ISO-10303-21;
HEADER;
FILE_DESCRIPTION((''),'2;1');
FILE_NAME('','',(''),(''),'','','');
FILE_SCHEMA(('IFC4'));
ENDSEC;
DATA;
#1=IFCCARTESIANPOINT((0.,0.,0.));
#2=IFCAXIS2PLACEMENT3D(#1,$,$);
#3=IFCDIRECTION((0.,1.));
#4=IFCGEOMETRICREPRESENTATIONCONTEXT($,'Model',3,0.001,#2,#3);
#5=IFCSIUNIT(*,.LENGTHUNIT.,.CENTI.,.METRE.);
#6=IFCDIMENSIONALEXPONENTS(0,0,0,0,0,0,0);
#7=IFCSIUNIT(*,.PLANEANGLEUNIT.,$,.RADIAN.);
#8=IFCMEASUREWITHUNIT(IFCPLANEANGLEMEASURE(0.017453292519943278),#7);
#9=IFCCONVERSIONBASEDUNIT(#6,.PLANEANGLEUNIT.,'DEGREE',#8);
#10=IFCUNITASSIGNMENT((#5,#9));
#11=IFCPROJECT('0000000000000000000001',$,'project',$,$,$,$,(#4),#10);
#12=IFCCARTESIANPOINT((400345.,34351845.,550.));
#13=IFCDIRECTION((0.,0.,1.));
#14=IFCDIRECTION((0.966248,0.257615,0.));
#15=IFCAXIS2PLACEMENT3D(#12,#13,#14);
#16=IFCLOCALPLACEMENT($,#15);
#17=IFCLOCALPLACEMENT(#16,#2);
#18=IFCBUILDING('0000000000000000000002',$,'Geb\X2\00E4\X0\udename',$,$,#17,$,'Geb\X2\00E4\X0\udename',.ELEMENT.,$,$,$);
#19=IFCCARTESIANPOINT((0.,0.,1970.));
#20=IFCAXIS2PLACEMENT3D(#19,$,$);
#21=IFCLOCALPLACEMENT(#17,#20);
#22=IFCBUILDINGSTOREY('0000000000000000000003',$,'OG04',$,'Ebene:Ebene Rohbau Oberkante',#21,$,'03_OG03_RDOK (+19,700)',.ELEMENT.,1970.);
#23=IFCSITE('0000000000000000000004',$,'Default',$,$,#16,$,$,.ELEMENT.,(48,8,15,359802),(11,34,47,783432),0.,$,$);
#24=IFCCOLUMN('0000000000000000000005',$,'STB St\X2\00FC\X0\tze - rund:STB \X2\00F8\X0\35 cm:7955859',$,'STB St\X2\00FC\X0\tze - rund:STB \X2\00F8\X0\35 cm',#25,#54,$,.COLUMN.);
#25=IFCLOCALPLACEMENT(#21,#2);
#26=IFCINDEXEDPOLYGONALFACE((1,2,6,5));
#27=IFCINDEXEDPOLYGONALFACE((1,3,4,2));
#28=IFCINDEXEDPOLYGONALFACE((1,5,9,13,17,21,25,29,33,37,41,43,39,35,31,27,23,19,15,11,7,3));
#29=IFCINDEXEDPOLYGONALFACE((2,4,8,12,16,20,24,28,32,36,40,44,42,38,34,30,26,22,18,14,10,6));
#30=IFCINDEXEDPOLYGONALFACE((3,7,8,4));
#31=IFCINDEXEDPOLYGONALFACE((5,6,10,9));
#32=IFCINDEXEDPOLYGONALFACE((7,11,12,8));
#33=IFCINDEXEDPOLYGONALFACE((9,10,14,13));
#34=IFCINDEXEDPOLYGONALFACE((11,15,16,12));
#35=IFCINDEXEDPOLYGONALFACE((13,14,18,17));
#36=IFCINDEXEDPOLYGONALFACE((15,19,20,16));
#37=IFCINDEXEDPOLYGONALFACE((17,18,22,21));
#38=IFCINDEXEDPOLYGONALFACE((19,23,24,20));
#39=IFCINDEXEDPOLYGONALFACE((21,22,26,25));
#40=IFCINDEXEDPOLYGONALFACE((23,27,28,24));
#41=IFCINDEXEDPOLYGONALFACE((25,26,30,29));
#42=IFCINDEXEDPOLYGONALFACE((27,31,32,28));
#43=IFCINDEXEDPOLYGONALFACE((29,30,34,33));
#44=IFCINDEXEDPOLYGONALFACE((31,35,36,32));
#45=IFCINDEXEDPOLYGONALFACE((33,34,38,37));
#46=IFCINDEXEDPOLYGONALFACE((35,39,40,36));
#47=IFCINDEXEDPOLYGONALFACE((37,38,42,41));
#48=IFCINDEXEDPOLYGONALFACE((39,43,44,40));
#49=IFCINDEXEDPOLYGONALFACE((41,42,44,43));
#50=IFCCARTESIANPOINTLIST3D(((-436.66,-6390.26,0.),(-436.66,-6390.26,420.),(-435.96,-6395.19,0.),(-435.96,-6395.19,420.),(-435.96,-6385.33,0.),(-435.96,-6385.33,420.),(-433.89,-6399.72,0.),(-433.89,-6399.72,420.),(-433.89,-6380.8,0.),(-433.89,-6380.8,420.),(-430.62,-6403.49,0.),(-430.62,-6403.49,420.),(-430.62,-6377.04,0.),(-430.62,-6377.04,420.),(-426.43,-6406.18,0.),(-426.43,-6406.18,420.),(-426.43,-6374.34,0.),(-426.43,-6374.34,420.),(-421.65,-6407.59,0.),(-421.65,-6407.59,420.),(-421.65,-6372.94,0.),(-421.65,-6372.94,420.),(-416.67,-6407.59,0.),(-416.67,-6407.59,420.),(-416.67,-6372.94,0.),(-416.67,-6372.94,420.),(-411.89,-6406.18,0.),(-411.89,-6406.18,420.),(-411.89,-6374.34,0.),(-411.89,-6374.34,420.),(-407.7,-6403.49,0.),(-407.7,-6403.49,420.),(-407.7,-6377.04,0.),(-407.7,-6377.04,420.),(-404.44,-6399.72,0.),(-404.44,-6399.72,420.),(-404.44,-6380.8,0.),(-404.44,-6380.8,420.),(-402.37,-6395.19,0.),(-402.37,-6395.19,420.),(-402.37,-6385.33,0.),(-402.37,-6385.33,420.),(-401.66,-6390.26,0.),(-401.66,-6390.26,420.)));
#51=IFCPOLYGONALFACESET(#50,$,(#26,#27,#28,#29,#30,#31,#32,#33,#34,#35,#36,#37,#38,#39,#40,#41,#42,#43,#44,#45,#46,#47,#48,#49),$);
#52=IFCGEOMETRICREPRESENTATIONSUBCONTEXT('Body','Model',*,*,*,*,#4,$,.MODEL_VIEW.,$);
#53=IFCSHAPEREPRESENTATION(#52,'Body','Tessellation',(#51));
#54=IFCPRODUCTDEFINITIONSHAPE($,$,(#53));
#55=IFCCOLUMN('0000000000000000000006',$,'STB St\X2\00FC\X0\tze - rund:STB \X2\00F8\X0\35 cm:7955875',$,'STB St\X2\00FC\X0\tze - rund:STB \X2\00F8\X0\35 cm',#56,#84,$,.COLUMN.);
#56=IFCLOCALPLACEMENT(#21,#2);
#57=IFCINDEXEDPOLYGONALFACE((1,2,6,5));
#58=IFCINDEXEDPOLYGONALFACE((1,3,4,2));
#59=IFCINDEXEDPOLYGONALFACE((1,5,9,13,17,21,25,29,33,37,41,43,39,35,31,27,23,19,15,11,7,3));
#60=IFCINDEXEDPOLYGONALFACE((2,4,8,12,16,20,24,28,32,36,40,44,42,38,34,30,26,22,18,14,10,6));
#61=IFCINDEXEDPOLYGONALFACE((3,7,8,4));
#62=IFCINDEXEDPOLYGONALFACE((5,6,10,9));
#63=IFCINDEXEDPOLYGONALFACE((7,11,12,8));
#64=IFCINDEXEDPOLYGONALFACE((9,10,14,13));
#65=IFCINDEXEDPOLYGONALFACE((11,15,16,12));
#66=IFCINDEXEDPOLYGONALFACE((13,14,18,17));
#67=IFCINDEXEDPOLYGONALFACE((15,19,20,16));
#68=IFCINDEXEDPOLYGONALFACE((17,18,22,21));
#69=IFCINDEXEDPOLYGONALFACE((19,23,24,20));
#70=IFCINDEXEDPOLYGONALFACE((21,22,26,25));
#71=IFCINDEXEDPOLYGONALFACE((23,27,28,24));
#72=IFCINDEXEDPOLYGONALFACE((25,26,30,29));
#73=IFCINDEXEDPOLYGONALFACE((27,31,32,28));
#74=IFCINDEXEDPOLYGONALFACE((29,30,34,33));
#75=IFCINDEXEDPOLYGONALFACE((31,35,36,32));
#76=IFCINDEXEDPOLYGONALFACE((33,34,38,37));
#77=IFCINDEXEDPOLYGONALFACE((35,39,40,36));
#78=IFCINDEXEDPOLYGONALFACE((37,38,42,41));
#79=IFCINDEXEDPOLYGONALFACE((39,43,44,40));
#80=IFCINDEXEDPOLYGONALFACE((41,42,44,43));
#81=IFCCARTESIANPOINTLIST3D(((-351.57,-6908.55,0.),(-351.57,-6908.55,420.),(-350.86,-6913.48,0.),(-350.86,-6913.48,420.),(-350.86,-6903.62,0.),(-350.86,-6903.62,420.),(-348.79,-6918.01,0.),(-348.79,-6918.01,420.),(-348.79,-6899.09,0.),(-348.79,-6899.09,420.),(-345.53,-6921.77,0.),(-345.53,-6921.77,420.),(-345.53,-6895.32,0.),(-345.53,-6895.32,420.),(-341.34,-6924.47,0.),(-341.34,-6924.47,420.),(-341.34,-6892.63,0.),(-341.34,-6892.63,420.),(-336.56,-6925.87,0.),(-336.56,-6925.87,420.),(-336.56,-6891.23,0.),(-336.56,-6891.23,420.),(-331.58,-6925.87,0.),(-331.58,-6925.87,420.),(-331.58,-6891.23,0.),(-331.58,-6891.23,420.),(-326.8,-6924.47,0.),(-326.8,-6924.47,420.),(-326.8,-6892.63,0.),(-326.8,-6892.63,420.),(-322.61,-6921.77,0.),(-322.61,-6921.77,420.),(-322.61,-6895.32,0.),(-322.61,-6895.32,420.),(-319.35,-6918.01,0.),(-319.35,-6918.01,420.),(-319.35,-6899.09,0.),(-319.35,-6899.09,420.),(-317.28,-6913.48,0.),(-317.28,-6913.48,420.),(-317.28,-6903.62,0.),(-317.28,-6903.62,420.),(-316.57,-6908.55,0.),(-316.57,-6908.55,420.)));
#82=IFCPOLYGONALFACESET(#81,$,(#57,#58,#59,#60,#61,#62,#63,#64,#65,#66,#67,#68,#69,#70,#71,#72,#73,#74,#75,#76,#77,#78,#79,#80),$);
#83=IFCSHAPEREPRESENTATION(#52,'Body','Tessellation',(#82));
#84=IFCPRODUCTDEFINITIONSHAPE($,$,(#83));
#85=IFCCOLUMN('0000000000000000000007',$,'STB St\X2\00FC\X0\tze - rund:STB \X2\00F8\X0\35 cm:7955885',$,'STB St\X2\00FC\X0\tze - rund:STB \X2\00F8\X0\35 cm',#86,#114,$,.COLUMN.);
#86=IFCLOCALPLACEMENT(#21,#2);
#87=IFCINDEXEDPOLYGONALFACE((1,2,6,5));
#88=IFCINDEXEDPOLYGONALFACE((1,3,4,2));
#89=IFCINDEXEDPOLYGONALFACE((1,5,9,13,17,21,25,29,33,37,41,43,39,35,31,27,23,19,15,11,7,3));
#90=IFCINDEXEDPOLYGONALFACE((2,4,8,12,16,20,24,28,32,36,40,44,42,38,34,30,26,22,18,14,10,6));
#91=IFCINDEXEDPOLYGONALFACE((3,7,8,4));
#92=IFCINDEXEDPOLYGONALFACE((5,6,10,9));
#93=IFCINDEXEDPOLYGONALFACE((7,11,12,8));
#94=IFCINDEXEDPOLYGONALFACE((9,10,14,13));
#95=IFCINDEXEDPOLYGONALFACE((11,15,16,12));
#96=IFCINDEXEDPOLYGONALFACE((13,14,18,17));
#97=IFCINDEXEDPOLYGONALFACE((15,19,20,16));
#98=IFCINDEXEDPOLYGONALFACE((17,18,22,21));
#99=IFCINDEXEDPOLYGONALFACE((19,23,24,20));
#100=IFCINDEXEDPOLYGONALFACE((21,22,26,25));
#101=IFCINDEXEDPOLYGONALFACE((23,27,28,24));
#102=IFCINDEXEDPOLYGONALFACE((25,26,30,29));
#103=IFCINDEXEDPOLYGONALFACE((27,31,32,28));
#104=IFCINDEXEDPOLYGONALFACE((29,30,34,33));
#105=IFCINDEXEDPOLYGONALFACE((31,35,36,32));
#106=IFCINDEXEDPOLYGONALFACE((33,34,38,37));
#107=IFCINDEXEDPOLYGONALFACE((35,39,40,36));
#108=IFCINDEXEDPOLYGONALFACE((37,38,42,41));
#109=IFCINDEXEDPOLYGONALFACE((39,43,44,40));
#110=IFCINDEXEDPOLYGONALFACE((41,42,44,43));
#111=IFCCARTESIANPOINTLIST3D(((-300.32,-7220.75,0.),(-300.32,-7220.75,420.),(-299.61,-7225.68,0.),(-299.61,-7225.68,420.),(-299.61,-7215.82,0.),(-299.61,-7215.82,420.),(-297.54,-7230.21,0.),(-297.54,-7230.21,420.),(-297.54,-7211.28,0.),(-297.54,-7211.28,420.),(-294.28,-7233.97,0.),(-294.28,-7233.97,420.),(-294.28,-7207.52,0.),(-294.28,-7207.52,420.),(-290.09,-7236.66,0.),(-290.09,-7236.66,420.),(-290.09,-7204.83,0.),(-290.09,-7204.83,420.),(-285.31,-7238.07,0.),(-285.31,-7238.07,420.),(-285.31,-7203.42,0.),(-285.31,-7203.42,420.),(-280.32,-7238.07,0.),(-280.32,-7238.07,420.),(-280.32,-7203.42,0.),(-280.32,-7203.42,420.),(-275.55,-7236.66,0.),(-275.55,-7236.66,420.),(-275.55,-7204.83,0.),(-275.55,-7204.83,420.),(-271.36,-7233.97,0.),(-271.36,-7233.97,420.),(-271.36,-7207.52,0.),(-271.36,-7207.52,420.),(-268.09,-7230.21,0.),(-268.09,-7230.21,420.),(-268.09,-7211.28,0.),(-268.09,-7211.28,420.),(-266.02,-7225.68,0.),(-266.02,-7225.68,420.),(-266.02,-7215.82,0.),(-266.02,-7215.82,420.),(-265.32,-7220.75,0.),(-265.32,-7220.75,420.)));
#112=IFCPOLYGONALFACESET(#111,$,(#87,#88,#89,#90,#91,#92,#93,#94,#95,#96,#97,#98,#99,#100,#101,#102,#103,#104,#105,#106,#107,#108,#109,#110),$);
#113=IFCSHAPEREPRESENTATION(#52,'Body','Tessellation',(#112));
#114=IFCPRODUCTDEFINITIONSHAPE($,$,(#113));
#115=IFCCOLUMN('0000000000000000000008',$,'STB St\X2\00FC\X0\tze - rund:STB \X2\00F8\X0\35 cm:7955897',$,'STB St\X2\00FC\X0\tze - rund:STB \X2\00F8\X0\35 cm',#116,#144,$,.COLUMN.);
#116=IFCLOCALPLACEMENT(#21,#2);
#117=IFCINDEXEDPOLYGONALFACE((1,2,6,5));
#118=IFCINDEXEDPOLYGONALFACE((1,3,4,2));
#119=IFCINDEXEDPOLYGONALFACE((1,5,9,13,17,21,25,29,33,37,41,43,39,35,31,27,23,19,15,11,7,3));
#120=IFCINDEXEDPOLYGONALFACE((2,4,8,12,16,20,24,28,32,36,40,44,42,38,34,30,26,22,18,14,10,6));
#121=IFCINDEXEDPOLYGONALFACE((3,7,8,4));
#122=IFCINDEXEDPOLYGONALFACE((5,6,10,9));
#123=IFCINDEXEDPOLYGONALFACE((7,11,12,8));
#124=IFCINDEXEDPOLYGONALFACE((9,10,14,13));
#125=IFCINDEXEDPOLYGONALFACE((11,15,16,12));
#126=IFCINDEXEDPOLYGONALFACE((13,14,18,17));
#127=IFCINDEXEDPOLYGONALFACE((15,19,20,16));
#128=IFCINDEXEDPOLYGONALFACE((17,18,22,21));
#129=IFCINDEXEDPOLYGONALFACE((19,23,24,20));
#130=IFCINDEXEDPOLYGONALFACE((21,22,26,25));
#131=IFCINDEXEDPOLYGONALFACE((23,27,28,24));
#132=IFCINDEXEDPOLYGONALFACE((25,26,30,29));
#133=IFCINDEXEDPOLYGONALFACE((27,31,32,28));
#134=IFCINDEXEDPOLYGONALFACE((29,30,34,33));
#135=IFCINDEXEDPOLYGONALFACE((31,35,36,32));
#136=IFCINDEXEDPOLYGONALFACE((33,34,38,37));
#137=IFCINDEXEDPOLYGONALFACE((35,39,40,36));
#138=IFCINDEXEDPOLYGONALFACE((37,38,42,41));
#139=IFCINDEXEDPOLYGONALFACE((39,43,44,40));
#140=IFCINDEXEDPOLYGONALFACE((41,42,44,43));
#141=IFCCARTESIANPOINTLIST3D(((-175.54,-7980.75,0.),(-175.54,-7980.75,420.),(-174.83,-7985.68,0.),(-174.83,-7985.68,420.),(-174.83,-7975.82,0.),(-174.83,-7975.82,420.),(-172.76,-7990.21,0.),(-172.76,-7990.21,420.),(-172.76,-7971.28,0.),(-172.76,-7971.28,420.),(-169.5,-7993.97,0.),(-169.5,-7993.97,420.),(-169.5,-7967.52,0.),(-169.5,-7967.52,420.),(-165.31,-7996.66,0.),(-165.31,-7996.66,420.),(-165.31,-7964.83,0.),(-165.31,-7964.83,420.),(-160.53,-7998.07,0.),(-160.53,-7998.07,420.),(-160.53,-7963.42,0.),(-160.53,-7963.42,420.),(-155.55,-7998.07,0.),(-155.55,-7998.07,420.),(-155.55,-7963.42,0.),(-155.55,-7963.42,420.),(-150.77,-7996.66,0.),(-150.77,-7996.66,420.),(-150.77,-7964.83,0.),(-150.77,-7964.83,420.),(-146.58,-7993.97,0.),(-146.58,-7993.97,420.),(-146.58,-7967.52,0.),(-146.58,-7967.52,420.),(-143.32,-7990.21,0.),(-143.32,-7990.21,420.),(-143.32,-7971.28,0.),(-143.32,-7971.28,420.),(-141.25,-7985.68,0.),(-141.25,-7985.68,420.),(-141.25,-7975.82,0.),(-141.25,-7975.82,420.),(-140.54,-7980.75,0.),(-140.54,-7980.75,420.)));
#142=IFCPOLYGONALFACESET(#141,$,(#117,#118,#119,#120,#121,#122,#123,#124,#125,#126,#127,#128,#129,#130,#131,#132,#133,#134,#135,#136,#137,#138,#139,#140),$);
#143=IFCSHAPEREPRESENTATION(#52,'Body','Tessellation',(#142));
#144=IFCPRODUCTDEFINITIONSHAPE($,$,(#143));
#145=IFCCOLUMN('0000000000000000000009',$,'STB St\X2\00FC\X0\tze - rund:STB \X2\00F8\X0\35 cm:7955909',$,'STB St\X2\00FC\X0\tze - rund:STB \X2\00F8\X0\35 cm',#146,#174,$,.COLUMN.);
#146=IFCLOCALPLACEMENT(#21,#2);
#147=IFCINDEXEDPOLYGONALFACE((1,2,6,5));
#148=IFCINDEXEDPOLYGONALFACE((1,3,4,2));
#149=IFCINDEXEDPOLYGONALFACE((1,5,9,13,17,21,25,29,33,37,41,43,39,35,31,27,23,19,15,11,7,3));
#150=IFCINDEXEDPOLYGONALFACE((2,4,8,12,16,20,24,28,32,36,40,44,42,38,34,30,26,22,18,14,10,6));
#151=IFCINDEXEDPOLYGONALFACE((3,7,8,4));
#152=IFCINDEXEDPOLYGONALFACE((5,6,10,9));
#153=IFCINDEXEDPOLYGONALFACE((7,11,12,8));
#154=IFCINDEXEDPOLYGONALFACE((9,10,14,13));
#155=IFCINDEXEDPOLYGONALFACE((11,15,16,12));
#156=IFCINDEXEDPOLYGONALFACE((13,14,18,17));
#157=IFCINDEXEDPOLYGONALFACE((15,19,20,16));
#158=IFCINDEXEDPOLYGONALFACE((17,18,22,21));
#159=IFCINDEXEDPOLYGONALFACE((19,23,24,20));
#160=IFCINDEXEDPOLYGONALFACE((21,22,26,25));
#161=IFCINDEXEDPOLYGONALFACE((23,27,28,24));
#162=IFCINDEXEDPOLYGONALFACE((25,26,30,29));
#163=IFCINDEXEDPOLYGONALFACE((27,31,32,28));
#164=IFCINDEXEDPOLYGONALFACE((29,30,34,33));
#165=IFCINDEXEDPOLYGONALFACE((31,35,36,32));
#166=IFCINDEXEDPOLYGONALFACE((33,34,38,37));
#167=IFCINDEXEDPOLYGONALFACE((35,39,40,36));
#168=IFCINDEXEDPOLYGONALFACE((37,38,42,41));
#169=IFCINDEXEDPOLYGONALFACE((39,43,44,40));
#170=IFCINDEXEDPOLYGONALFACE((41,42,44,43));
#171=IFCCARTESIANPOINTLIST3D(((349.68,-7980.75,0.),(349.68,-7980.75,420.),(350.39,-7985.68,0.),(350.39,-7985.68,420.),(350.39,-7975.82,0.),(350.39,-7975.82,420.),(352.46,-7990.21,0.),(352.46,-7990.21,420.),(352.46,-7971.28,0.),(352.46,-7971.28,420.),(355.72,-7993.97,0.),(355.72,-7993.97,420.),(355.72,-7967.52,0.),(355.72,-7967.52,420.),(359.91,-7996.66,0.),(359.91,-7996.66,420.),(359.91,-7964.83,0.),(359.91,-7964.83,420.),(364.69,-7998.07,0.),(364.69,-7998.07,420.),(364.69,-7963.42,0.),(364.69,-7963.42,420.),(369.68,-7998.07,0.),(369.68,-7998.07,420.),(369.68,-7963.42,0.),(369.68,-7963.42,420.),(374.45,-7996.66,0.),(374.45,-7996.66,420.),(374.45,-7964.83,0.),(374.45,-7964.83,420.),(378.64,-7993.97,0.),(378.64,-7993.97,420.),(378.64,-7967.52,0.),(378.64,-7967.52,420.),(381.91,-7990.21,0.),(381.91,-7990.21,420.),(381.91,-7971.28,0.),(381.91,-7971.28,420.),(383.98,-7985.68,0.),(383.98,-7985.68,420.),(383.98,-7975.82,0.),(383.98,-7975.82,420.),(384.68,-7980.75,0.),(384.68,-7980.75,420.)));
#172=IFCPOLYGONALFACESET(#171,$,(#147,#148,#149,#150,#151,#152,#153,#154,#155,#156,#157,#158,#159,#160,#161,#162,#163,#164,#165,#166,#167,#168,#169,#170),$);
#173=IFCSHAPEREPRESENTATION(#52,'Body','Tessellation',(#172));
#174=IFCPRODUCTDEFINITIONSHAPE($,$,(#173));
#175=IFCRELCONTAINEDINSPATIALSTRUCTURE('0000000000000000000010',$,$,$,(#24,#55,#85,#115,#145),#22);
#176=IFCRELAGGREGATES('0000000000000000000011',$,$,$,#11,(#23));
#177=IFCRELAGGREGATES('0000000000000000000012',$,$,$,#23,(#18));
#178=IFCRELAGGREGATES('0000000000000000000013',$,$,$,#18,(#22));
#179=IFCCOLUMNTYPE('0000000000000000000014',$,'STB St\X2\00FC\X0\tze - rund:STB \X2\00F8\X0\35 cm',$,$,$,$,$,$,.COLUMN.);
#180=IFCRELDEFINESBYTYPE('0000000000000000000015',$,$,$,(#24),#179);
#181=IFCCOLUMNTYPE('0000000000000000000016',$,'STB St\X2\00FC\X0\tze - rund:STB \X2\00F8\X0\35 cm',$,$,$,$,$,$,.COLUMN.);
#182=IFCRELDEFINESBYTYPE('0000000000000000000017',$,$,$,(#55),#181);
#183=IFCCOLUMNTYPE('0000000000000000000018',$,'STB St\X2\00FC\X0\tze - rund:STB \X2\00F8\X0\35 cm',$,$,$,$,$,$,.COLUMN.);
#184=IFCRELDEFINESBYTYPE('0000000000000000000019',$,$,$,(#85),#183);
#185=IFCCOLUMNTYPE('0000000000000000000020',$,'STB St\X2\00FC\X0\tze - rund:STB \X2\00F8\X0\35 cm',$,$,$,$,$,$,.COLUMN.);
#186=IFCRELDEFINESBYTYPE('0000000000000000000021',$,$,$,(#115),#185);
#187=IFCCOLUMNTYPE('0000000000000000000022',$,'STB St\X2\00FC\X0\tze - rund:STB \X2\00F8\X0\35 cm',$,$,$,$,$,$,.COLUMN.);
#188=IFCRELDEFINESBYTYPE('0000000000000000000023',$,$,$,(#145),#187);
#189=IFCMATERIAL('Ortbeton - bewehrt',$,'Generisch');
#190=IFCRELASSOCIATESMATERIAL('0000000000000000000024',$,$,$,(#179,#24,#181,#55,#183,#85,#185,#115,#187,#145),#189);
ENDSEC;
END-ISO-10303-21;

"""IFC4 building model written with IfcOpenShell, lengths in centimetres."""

from ifc_helpers import new_model, entity, si_unit, converted_unit, direction, frame, origin, place, context, subcontext, project, spatial, arc, indexed_curve, outline, extrude, source, transform, mapped, material, type_object, type_shapes, element, save


model = new_model("IFC4")

# Units and contexts
model_context = context("Model", 3, precision=0.001, world=origin(), true_north=direction((0.0, 1.0)))
body_context = subcontext(model_context, "Body", "Model", "MODEL_VIEW")
ifc_project = project(units=[si_unit("LENGTHUNIT", "METRE", prefix="CENTI"), converted_unit("PLANEANGLEUNIT", "DEGREE", entity("IfcPlaneAngleMeasure", 0.017453292519943278), si_unit("PLANEANGLEUNIT", "RADIAN"), dimensions=[0, 0, 0, 0, 0, 0, 0])], contexts=[model_context])

# Site, building, storey
site_placement = place(None, frame((400345.0, 34351845.0, 550.0), z_axis=(0.0, 0.0, 1.0), x_axis=(0.966248, 0.257615, 0.0)))
site = spatial("IfcSite", under=ifc_project, at=site_placement, Name="Default", CompositionType="ELEMENT", RefLatitude=(48, 8, 15, 359802), RefLongitude=(11, 34, 47, 783432), RefElevation=0.0)
building_placement = place(site_placement, origin())
building = spatial("IfcBuilding", under=site, at=building_placement, Name="Gebäudename", LongName="Gebäudename", CompositionType="ELEMENT")
storey_placement = place(building_placement, frame((0.0, 0.0, 1970.0)))
storey = spatial("IfcBuildingStorey", under=building, at=storey_placement, Name="OG04", ObjectType="Ebene:Ebene Rohbau Oberkante", LongName="03_OG03_RDOK (+19,700)", CompositionType="ELEMENT", Elevation=1970.0)

# Columns
ifc_material = material(Name="Ortbeton - bewehrt", Category="Generisch")
column_type_1 = type_object("IfcColumnType", Name="STB Stütze - rund:STB ø35 cm", PredefinedType="COLUMN", material=ifc_material)
shared_shape_1 = source(origin(), body_context, "Body", "SweptSolid", [
    extrude(outline(indexed_curve([(-17.5, 0.0), (0.0, -17.5), (17.5, 0.0), (0.0, 17.5)], segments=[arc(1, 2, 3), arc(3, 4, 1)], self_intersect=False)), frame((-419.16, -6390.26, 1970.0)), (0.0, 0.0, 1.0), 420.0),
])
type_shapes(column_type_1, [shared_shape_1])
column_1_placement = place(storey_placement, frame((0.0, 0.0, -1970.0)))
element("IfcColumn", 1, at=column_1_placement, inside=storey, type_object=column_type_1, material=ifc_material, Name="STB Stütze - rund:STB ø35 cm:7955859", ObjectType="STB Stütze - rund:STB ø35 cm", PredefinedType="COLUMN", context=body_context, shape_type="MappedRepresentation", body=[
    mapped(shared_shape_1, transform((0.0, 0.0, 0.0), scale=1.0)),
])
column_type_2 = type_object("IfcColumnType", Name="STB Stütze - rund:STB ø35 cm", PredefinedType="COLUMN", material=ifc_material)
shared_shape_2 = source(origin(), body_context, "Body", "SweptSolid", [
    extrude(outline(indexed_curve([(-17.5, 0.0), (0.0, -17.5), (17.5, 0.0), (0.0, 17.5)], segments=[arc(1, 2, 3), arc(3, 4, 1)], self_intersect=False)), frame((-334.07, -6908.55, 1970.0)), (0.0, 0.0, 1.0), 420.0),
])
type_shapes(column_type_2, [shared_shape_2])
column_2_placement = place(storey_placement, frame((0.0, 0.0, -1970.0)))
element("IfcColumn", 2, at=column_2_placement, inside=storey, type_object=column_type_2, material=ifc_material, Name="STB Stütze - rund:STB ø35 cm:7955875", ObjectType="STB Stütze - rund:STB ø35 cm", PredefinedType="COLUMN", context=body_context, shape_type="MappedRepresentation", body=[
    mapped(shared_shape_2, transform((0.0, 0.0, 0.0), scale=1.0)),
])
column_type_3 = type_object("IfcColumnType", Name="STB Stütze - rund:STB ø35 cm", PredefinedType="COLUMN", material=ifc_material)
shared_shape_3 = source(origin(), body_context, "Body", "SweptSolid", [
    extrude(outline(indexed_curve([(-17.5, 0.0), (0.0, -17.5), (17.5, 0.0), (0.0, 17.5)], segments=[arc(1, 2, 3), arc(3, 4, 1)], self_intersect=False)), frame((-282.82, -7220.75, 1970.0)), (0.0, 0.0, 1.0), 420.0),
])
type_shapes(column_type_3, [shared_shape_3])
column_3_placement = place(storey_placement, frame((0.0, 0.0, -1970.0)))
element("IfcColumn", 3, at=column_3_placement, inside=storey, type_object=column_type_3, material=ifc_material, Name="STB Stütze - rund:STB ø35 cm:7955885", ObjectType="STB Stütze - rund:STB ø35 cm", PredefinedType="COLUMN", context=body_context, shape_type="MappedRepresentation", body=[
    mapped(shared_shape_3, transform((0.0, 0.0, 0.0), scale=1.0)),
])
column_type_4 = type_object("IfcColumnType", Name="STB Stütze - rund:STB ø35 cm", PredefinedType="COLUMN", material=ifc_material)
shared_shape_4 = source(origin(), body_context, "Body", "SweptSolid", [
    extrude(outline(indexed_curve([(-17.5, 0.0), (0.0, -17.5), (17.5, 0.0), (0.0, 17.5)], segments=[arc(1, 2, 3), arc(3, 4, 1)], self_intersect=False)), frame((-158.04, -7980.75, 1970.0)), (0.0, 0.0, 1.0), 420.0),
])
type_shapes(column_type_4, [shared_shape_4])
column_4_placement = place(storey_placement, frame((0.0, 0.0, -1970.0)))
element("IfcColumn", 4, at=column_4_placement, inside=storey, type_object=column_type_4, material=ifc_material, Name="STB Stütze - rund:STB ø35 cm:7955897", ObjectType="STB Stütze - rund:STB ø35 cm", PredefinedType="COLUMN", context=body_context, shape_type="MappedRepresentation", body=[
    mapped(shared_shape_4, transform((0.0, 0.0, 0.0), scale=1.0)),
])
column_type_5 = type_object("IfcColumnType", Name="STB Stütze - rund:STB ø35 cm", PredefinedType="COLUMN", material=ifc_material)
shared_shape_5 = source(origin(), body_context, "Body", "SweptSolid", [
    extrude(outline(indexed_curve([(-17.5, 0.0), (0.0, -17.5), (17.5, 0.0), (0.0, 17.5)], segments=[arc(1, 2, 3), arc(3, 4, 1)], self_intersect=False)), frame((367.18, -7980.75, 1970.0)), (0.0, 0.0, 1.0), 420.0),
])
type_shapes(column_type_5, [shared_shape_5])
column_5_placement = place(storey_placement, frame((0.0, 0.0, -1970.0)))
element("IfcColumn", 5, at=column_5_placement, inside=storey, type_object=column_type_5, material=ifc_material, Name="STB Stütze - rund:STB ø35 cm:7955909", ObjectType="STB Stütze - rund:STB ø35 cm", PredefinedType="COLUMN", context=body_context, shape_type="MappedRepresentation", body=[
    mapped(shared_shape_5, transform((0.0, 0.0, 0.0), scale=1.0)),
])

save(model, "model.ifc")
